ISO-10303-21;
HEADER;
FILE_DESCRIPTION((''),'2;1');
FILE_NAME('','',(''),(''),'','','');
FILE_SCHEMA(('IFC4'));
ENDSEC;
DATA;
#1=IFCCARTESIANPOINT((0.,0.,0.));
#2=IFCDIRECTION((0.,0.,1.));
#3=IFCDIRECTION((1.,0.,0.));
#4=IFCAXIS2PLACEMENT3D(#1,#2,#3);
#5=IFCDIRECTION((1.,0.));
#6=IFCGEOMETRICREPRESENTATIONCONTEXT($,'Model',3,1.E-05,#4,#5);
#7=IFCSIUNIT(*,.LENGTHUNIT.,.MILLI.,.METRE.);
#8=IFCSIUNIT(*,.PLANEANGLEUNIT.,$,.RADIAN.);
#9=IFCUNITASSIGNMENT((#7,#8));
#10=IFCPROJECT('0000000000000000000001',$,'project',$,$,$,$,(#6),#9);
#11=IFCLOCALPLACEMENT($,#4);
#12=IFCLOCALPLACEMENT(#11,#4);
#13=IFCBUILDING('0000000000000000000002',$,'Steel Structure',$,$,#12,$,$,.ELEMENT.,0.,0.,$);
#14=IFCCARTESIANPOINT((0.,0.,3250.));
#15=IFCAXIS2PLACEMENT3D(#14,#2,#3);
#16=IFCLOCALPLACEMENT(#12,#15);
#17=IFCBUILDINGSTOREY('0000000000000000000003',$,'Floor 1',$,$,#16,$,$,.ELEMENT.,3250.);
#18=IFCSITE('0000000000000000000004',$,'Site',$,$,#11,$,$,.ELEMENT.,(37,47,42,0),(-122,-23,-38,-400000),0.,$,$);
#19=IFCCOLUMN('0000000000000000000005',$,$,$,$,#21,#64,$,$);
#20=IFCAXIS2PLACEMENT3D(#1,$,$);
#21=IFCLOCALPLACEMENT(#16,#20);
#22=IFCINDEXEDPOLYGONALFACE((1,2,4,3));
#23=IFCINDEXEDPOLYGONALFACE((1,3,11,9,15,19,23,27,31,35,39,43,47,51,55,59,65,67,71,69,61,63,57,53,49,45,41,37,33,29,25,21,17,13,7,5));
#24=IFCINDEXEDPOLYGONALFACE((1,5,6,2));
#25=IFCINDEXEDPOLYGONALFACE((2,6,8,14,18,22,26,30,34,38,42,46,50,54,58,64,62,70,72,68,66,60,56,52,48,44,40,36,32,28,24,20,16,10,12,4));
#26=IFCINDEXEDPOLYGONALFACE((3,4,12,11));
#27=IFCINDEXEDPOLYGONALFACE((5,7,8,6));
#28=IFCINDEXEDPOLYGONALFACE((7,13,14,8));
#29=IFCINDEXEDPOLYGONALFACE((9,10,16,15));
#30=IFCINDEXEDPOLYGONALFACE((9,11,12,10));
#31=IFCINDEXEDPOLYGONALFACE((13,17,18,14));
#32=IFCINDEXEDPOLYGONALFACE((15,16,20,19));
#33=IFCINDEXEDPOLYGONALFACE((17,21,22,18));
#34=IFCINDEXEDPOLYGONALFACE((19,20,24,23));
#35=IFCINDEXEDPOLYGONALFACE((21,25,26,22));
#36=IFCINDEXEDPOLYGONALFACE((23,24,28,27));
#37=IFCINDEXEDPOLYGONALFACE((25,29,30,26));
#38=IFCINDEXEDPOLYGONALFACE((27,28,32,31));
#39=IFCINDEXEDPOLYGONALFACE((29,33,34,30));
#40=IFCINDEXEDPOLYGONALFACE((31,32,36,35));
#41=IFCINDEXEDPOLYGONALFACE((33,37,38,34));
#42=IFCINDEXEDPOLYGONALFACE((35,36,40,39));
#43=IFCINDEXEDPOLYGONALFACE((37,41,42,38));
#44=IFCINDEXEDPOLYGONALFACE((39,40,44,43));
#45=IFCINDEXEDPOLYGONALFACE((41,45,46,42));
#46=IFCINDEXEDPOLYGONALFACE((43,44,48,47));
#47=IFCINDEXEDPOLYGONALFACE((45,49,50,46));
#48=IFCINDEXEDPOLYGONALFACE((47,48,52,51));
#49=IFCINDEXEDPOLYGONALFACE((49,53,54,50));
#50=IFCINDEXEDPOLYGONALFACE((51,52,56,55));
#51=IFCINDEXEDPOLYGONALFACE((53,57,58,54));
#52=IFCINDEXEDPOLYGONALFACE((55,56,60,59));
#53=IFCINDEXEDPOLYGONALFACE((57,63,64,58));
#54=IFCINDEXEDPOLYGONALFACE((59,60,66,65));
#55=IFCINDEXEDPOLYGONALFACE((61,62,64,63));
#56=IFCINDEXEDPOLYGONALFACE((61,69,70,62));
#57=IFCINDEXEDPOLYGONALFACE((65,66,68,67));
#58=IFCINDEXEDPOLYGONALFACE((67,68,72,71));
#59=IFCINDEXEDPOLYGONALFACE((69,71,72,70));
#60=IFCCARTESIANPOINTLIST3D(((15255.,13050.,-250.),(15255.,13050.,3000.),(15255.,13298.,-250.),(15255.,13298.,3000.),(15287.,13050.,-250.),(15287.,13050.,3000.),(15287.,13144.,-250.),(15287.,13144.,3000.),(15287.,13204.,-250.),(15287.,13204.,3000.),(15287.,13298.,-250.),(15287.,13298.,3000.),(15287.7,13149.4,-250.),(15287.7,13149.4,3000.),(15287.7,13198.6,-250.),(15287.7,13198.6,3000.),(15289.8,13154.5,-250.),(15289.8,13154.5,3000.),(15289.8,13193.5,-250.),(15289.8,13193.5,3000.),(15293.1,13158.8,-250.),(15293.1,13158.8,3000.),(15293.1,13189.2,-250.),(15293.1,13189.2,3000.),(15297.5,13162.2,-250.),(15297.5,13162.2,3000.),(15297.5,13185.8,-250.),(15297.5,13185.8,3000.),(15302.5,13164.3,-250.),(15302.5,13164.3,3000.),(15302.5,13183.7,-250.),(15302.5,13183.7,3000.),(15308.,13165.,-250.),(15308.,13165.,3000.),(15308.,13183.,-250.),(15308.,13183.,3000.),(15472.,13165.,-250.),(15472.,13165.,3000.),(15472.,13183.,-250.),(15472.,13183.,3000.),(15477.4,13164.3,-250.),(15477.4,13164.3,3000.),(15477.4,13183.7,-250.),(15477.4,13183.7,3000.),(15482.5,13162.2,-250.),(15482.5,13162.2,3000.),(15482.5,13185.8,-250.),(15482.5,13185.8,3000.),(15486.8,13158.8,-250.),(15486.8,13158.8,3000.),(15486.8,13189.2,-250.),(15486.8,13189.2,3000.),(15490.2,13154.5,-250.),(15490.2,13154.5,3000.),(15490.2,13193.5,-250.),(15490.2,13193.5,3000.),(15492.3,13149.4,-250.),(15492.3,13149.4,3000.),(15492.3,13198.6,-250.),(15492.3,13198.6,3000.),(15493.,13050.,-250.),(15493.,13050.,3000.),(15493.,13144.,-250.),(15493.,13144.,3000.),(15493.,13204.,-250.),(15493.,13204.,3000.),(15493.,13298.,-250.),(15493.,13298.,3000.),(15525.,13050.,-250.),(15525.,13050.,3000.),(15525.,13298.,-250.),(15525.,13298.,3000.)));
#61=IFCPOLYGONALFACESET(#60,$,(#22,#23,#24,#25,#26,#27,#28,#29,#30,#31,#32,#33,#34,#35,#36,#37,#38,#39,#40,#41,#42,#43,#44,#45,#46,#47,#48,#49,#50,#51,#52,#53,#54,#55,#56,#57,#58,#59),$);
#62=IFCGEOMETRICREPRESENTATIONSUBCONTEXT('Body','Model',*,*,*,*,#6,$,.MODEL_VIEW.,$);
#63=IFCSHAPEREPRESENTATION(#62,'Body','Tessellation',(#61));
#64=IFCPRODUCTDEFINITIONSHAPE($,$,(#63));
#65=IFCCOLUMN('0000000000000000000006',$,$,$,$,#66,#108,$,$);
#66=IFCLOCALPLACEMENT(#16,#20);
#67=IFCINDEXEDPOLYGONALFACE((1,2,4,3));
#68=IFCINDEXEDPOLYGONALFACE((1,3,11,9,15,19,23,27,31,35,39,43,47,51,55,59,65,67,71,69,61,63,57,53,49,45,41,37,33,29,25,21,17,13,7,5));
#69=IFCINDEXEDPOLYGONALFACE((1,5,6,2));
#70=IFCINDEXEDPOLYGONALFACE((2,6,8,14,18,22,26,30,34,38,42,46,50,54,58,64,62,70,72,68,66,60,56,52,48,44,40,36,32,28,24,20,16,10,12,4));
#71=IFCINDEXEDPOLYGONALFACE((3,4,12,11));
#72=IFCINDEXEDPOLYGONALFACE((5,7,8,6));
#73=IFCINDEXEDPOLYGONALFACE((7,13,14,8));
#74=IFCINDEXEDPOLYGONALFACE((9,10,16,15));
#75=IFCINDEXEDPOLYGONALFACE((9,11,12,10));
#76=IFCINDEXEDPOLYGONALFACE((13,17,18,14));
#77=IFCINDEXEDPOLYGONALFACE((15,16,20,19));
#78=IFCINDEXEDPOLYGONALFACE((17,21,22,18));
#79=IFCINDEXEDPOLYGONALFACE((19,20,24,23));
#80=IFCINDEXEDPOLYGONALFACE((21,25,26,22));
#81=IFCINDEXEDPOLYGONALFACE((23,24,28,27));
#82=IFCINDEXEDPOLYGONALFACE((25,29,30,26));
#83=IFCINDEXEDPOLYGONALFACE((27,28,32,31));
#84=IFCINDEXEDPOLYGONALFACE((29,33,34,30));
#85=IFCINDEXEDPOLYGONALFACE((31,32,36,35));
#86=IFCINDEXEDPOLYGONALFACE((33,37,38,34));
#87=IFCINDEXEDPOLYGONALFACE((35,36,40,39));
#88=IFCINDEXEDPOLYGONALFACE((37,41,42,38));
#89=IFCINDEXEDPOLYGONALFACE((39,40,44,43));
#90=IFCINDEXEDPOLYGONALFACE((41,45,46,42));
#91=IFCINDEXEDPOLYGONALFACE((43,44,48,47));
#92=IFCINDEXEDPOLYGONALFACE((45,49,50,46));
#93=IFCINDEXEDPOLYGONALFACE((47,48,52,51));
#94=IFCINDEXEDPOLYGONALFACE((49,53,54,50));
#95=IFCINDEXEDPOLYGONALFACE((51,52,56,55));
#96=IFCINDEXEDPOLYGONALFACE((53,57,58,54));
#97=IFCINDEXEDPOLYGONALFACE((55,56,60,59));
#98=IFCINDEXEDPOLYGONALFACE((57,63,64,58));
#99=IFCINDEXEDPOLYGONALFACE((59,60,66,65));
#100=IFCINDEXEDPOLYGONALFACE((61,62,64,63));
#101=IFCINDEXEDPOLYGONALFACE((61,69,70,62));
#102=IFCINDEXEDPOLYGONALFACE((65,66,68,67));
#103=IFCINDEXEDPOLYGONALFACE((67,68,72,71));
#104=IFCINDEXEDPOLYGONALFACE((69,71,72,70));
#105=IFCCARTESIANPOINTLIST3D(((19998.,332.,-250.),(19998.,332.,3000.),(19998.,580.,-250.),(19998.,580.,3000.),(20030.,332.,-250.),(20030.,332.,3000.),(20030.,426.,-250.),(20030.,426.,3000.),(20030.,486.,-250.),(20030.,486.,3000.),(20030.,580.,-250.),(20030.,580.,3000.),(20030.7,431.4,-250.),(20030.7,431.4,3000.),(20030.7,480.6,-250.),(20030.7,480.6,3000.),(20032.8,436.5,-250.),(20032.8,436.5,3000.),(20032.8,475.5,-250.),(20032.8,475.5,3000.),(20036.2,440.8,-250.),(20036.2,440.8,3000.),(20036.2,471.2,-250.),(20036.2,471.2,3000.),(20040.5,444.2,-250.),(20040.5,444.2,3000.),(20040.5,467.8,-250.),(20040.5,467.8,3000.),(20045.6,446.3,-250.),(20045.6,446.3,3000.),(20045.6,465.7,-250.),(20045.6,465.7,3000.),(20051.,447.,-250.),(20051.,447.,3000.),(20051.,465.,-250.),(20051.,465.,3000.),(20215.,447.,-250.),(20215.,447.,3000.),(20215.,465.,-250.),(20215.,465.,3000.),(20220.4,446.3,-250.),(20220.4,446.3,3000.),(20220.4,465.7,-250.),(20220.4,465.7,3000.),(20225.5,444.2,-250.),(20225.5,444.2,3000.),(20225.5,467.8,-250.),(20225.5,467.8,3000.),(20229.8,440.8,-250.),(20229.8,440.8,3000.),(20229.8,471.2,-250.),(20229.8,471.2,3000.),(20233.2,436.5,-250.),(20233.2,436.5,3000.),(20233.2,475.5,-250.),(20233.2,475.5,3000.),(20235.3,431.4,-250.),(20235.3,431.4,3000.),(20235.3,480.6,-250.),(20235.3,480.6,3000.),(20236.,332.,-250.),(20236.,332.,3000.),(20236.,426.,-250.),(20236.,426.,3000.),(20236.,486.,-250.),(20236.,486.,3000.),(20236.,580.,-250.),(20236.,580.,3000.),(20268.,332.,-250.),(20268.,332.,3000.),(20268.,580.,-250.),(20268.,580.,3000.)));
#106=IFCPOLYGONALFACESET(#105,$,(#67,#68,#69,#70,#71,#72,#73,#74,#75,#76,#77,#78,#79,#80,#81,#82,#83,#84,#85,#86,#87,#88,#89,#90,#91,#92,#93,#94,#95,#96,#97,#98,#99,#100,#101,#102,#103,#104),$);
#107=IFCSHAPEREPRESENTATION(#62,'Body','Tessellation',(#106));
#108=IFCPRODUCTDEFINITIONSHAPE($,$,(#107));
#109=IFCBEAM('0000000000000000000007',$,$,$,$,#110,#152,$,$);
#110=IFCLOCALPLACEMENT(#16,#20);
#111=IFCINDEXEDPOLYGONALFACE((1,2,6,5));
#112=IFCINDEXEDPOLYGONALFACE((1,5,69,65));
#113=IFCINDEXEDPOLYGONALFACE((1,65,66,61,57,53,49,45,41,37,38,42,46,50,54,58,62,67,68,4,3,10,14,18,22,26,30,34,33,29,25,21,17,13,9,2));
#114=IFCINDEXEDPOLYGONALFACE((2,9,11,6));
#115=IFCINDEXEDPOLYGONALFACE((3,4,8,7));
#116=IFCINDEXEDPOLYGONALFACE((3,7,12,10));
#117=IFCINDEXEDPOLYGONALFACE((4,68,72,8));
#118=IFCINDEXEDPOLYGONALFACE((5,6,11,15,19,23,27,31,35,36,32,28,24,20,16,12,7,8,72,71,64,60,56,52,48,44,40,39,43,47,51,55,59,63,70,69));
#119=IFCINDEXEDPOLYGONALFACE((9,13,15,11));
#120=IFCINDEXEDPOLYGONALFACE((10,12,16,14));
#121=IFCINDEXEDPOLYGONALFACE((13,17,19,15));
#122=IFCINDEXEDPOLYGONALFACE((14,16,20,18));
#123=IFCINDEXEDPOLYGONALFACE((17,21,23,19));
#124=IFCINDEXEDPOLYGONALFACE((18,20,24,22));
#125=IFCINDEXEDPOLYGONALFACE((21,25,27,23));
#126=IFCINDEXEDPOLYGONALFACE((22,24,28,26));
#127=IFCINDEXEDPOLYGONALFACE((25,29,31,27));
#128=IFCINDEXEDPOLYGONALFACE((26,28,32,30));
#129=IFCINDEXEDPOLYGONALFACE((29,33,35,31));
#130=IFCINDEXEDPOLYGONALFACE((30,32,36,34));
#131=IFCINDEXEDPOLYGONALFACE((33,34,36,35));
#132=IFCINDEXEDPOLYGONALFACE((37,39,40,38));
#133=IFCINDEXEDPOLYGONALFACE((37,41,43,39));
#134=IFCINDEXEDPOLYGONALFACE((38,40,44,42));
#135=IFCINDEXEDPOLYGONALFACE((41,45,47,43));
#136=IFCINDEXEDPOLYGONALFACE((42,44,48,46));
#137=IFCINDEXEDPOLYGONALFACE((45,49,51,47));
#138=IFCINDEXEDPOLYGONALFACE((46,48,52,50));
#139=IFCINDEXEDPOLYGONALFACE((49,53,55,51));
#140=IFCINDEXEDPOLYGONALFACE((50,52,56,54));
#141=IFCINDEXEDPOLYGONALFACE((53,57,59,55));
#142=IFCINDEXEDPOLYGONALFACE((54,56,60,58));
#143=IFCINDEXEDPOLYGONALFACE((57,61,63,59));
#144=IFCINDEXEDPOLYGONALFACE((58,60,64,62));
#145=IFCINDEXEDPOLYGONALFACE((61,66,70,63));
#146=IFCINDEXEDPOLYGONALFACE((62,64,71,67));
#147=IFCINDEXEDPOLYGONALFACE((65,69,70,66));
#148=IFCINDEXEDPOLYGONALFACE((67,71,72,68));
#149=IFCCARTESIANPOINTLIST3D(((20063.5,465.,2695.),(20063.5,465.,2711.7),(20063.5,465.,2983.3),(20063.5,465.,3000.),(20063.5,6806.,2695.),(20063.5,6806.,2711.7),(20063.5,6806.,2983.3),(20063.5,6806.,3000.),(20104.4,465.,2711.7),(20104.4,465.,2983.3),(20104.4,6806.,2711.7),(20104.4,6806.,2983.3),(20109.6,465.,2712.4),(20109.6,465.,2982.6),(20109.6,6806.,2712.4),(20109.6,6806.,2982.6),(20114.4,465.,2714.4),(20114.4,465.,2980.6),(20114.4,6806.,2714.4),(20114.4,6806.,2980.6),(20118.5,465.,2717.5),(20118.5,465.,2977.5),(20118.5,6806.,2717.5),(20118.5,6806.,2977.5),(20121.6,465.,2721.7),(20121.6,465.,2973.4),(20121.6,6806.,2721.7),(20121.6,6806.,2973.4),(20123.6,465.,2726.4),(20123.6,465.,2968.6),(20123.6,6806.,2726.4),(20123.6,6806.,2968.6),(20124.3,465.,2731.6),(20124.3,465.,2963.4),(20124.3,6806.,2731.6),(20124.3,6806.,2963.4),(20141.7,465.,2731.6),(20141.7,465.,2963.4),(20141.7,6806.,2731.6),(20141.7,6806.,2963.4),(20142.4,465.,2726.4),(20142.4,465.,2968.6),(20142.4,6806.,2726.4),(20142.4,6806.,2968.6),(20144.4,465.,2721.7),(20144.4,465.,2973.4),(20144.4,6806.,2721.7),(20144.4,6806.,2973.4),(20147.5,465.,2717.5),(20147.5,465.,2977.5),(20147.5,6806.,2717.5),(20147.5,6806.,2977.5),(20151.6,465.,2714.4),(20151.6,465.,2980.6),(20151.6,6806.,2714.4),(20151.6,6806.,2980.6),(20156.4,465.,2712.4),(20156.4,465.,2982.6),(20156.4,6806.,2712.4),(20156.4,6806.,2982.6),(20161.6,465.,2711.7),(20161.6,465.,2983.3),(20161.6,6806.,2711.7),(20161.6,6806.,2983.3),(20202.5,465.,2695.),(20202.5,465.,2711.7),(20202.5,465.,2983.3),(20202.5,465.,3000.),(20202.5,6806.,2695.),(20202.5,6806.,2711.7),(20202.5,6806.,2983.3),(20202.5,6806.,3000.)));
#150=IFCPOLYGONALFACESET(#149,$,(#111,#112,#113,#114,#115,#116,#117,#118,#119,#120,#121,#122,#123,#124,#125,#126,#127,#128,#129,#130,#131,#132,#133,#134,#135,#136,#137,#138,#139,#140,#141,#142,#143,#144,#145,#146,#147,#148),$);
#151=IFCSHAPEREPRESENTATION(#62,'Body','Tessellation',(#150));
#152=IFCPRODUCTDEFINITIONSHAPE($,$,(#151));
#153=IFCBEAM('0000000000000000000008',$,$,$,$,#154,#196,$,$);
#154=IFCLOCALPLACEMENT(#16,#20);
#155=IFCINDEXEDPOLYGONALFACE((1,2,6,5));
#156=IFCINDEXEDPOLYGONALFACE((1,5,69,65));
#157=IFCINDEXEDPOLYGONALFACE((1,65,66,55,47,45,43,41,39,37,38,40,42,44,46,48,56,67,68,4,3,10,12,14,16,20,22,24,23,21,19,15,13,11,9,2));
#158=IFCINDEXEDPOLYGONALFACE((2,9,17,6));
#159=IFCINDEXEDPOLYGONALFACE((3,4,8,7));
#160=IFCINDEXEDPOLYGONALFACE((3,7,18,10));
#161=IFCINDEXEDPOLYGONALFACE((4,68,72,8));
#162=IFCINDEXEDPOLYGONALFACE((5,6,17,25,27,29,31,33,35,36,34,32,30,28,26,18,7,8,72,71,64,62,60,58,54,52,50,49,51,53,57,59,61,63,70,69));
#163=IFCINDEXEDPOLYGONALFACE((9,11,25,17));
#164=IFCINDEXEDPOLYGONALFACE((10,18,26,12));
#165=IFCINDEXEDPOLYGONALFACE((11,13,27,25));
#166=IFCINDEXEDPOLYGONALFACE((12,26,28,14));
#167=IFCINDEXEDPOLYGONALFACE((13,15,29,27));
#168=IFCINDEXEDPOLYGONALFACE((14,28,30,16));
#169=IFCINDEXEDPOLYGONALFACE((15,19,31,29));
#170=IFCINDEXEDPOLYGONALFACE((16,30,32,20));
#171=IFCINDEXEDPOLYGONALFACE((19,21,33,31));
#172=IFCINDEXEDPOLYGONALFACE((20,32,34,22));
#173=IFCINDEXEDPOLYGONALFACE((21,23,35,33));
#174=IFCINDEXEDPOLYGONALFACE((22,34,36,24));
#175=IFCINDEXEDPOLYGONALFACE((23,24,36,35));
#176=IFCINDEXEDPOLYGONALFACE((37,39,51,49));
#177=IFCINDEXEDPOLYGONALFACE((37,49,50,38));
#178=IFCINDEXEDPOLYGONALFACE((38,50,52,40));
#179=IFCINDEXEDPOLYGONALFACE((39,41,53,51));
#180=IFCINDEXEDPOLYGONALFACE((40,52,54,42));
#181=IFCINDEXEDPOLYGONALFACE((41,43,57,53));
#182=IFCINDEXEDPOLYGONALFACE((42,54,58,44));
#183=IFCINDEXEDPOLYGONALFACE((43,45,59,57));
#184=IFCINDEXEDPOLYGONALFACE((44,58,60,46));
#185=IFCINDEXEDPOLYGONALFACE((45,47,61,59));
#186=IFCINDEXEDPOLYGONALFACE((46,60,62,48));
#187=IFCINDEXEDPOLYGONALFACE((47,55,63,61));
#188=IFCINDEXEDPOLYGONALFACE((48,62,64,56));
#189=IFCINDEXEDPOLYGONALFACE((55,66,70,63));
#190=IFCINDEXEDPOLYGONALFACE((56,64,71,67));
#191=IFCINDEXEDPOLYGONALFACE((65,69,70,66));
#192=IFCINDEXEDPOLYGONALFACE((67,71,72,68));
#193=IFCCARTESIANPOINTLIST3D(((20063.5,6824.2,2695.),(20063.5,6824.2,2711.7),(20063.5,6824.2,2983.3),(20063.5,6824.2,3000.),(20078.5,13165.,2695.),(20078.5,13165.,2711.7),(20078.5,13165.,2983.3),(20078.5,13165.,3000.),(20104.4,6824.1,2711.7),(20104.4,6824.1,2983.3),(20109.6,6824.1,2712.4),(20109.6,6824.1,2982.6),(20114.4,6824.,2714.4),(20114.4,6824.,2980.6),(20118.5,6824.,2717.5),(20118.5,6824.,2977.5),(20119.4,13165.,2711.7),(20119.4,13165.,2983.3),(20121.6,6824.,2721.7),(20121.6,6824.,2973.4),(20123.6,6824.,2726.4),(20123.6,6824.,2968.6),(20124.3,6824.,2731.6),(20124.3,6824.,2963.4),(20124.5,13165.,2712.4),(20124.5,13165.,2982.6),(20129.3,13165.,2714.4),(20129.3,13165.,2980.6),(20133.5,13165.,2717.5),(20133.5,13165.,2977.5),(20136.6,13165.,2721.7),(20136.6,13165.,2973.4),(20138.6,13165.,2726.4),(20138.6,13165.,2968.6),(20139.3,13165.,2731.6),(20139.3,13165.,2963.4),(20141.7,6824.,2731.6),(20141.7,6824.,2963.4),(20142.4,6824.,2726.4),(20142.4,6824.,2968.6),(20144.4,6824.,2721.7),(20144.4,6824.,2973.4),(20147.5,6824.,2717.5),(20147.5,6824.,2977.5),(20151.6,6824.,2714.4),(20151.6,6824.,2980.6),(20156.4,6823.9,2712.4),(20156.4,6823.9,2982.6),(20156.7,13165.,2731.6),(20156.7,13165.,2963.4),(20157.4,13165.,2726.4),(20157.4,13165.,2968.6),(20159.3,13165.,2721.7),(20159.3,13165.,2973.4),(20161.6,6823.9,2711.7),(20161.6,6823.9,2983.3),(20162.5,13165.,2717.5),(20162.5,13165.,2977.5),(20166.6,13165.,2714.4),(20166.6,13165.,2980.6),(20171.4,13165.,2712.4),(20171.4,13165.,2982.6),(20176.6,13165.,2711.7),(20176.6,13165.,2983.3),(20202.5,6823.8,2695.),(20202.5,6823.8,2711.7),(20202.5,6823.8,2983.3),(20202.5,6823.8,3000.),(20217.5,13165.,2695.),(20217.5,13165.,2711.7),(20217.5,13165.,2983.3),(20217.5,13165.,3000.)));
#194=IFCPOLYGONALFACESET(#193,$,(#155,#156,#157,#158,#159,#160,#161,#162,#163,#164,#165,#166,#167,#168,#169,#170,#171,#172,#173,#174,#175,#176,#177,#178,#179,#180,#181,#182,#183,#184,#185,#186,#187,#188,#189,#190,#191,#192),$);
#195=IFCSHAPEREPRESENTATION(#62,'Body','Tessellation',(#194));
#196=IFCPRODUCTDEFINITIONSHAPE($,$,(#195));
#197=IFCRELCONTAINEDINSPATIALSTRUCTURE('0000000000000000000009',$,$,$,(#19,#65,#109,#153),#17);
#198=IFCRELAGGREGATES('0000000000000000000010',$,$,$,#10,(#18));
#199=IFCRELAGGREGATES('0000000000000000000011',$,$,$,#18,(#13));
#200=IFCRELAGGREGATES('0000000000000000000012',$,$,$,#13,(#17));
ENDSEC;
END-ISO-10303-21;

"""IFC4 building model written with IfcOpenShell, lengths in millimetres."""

from ifc_helpers import new_model, si_unit, direction, frame, origin_with_axes, origin_2d_with_axis, place, context, subcontext, project, spatial, polyline, i_section, extrude, clip, bounded_halfspace, element, save


model = new_model("IFC4")

# Units and contexts
model_context = context("Model", 3, precision=1e-05, world=origin_with_axes(), true_north=direction((1.0, 0.0)))
body_context = subcontext(model_context, "Body", "Model", "MODEL_VIEW")
ifc_project = project(units=[si_unit("LENGTHUNIT", "METRE", prefix="MILLI"), si_unit("PLANEANGLEUNIT", "RADIAN")], contexts=[model_context])

# Site, building, storey
site_placement = place(None, origin_with_axes())
site = spatial("IfcSite", under=ifc_project, at=site_placement, Name="Site", CompositionType="ELEMENT", RefLatitude=(37, 47, 42, 0), RefLongitude=(-122, -23, -38, -400000), RefElevation=0.0)
building_placement = place(site_placement, origin_with_axes())
building = spatial("IfcBuilding", under=site, at=building_placement, Name="Steel Structure", CompositionType="ELEMENT", ElevationOfRefHeight=0.0, ElevationOfTerrain=0.0)
storey_placement = place(building_placement, frame((0.0, 0.0, 3250.0), z_axis=(0.0, 0.0, 1.0), x_axis=(1.0, 0.0, 0.0)))
storey = spatial("IfcBuildingStorey", under=building, at=storey_placement, Name="Floor 1", CompositionType="ELEMENT", Elevation=3250.0)

# Columns
column_1_placement = place(storey_placement, frame((15390.0, 13174.0, -250.0), z_axis=(0.0, 0.0, 1.0), x_axis=(0.0, 1.0, 0.0)))
element("IfcColumn", 1, at=column_1_placement, inside=storey, context=body_context, shape_type="SweptSolid", body=[
    extrude(i_section(OverallWidth=248.0, OverallDepth=270.0, WebThickness=18.0, FlangeThickness=32.0, FilletRadius=21.0, at=origin_2d_with_axis()), origin_with_axes(), (0.0, 0.0, 1.0), 3250.0),
])
column_2_placement = place(storey_placement, frame((20133.0, 456.0, -250.0), z_axis=(0.0, 0.0, 1.0), x_axis=(0.0, 1.0, 0.0)))
element("IfcColumn", 2, at=column_2_placement, inside=storey, context=body_context, shape_type="SweptSolid", body=[
    extrude(i_section(OverallWidth=248.0, OverallDepth=270.0, WebThickness=18.0, FlangeThickness=32.0, FilletRadius=21.0, at=origin_2d_with_axis()), origin_with_axes(), (0.0, 0.0, 1.0), 3250.0),
])

# Beams
beam_1_placement = place(storey_placement, frame((20133.0, 6806.0, 2847.5), z_axis=(0.0, -1.0, 0.0), x_axis=(1.0, 0.0, 0.0)))
element("IfcBeam", 3, at=beam_1_placement, inside=storey, context=body_context, shape_type="SweptSolid", body=[
    extrude(i_section(OverallWidth=139.0, OverallDepth=305.0, WebThickness=17.4, FlangeThickness=16.7, FilletRadius=19.9, at=origin_2d_with_axis()), origin_with_axes(), (0.0, 0.0, 1.0), 6341.0),
])
beam_2_placement = place(storey_placement, frame((20148.0, 13165.2, 2695.0), z_axis=(-0.002362, -0.999997, 0.0), x_axis=(0.999997, -0.002362, 0.0)))
element("IfcBeam", 4, at=beam_2_placement, inside=storey, context=body_context, shape_type="Clipping", body=[
    clip(extrude(i_section(OverallWidth=139.0, OverallDepth=305.0, WebThickness=17.4, FlangeThickness=16.7, FilletRadius=19.9, at=origin_2d_with_axis()), frame((0.0, 152.5, 0.0), z_axis=(0.0, 0.0, 1.0), x_axis=(1.0, 0.0, 0.0)), (0.0, 0.0, 1.0), 6341.2), bounded_halfspace(frame((-20147.9, -5945.0, 47.8), z_axis=(-0.002362, 0.0, -0.999997), x_axis=(-0.999997, 0.0, 0.002362)), False, frame((0.0, 152.5, 0.0), z_axis=(0.0, 0.0, 1.0), x_axis=(1.0, 0.0, 0.0)), polyline([(69.5, 152.5), (69.5, 135.8), (28.6, 135.8), (8.7, 115.9), (8.7, -115.9), (28.6, -135.8), (69.5, -135.8), (69.5, -152.5), (-69.5, -152.5), (-69.5, -135.8), (-28.6, -135.8), (-8.7, -115.9), (-8.7, 115.9), (-28.6, 135.8), (-69.5, 135.8), (-69.5, 152.5), (69.5, 152.5)]))),
])

save(model, "model.ifc")
